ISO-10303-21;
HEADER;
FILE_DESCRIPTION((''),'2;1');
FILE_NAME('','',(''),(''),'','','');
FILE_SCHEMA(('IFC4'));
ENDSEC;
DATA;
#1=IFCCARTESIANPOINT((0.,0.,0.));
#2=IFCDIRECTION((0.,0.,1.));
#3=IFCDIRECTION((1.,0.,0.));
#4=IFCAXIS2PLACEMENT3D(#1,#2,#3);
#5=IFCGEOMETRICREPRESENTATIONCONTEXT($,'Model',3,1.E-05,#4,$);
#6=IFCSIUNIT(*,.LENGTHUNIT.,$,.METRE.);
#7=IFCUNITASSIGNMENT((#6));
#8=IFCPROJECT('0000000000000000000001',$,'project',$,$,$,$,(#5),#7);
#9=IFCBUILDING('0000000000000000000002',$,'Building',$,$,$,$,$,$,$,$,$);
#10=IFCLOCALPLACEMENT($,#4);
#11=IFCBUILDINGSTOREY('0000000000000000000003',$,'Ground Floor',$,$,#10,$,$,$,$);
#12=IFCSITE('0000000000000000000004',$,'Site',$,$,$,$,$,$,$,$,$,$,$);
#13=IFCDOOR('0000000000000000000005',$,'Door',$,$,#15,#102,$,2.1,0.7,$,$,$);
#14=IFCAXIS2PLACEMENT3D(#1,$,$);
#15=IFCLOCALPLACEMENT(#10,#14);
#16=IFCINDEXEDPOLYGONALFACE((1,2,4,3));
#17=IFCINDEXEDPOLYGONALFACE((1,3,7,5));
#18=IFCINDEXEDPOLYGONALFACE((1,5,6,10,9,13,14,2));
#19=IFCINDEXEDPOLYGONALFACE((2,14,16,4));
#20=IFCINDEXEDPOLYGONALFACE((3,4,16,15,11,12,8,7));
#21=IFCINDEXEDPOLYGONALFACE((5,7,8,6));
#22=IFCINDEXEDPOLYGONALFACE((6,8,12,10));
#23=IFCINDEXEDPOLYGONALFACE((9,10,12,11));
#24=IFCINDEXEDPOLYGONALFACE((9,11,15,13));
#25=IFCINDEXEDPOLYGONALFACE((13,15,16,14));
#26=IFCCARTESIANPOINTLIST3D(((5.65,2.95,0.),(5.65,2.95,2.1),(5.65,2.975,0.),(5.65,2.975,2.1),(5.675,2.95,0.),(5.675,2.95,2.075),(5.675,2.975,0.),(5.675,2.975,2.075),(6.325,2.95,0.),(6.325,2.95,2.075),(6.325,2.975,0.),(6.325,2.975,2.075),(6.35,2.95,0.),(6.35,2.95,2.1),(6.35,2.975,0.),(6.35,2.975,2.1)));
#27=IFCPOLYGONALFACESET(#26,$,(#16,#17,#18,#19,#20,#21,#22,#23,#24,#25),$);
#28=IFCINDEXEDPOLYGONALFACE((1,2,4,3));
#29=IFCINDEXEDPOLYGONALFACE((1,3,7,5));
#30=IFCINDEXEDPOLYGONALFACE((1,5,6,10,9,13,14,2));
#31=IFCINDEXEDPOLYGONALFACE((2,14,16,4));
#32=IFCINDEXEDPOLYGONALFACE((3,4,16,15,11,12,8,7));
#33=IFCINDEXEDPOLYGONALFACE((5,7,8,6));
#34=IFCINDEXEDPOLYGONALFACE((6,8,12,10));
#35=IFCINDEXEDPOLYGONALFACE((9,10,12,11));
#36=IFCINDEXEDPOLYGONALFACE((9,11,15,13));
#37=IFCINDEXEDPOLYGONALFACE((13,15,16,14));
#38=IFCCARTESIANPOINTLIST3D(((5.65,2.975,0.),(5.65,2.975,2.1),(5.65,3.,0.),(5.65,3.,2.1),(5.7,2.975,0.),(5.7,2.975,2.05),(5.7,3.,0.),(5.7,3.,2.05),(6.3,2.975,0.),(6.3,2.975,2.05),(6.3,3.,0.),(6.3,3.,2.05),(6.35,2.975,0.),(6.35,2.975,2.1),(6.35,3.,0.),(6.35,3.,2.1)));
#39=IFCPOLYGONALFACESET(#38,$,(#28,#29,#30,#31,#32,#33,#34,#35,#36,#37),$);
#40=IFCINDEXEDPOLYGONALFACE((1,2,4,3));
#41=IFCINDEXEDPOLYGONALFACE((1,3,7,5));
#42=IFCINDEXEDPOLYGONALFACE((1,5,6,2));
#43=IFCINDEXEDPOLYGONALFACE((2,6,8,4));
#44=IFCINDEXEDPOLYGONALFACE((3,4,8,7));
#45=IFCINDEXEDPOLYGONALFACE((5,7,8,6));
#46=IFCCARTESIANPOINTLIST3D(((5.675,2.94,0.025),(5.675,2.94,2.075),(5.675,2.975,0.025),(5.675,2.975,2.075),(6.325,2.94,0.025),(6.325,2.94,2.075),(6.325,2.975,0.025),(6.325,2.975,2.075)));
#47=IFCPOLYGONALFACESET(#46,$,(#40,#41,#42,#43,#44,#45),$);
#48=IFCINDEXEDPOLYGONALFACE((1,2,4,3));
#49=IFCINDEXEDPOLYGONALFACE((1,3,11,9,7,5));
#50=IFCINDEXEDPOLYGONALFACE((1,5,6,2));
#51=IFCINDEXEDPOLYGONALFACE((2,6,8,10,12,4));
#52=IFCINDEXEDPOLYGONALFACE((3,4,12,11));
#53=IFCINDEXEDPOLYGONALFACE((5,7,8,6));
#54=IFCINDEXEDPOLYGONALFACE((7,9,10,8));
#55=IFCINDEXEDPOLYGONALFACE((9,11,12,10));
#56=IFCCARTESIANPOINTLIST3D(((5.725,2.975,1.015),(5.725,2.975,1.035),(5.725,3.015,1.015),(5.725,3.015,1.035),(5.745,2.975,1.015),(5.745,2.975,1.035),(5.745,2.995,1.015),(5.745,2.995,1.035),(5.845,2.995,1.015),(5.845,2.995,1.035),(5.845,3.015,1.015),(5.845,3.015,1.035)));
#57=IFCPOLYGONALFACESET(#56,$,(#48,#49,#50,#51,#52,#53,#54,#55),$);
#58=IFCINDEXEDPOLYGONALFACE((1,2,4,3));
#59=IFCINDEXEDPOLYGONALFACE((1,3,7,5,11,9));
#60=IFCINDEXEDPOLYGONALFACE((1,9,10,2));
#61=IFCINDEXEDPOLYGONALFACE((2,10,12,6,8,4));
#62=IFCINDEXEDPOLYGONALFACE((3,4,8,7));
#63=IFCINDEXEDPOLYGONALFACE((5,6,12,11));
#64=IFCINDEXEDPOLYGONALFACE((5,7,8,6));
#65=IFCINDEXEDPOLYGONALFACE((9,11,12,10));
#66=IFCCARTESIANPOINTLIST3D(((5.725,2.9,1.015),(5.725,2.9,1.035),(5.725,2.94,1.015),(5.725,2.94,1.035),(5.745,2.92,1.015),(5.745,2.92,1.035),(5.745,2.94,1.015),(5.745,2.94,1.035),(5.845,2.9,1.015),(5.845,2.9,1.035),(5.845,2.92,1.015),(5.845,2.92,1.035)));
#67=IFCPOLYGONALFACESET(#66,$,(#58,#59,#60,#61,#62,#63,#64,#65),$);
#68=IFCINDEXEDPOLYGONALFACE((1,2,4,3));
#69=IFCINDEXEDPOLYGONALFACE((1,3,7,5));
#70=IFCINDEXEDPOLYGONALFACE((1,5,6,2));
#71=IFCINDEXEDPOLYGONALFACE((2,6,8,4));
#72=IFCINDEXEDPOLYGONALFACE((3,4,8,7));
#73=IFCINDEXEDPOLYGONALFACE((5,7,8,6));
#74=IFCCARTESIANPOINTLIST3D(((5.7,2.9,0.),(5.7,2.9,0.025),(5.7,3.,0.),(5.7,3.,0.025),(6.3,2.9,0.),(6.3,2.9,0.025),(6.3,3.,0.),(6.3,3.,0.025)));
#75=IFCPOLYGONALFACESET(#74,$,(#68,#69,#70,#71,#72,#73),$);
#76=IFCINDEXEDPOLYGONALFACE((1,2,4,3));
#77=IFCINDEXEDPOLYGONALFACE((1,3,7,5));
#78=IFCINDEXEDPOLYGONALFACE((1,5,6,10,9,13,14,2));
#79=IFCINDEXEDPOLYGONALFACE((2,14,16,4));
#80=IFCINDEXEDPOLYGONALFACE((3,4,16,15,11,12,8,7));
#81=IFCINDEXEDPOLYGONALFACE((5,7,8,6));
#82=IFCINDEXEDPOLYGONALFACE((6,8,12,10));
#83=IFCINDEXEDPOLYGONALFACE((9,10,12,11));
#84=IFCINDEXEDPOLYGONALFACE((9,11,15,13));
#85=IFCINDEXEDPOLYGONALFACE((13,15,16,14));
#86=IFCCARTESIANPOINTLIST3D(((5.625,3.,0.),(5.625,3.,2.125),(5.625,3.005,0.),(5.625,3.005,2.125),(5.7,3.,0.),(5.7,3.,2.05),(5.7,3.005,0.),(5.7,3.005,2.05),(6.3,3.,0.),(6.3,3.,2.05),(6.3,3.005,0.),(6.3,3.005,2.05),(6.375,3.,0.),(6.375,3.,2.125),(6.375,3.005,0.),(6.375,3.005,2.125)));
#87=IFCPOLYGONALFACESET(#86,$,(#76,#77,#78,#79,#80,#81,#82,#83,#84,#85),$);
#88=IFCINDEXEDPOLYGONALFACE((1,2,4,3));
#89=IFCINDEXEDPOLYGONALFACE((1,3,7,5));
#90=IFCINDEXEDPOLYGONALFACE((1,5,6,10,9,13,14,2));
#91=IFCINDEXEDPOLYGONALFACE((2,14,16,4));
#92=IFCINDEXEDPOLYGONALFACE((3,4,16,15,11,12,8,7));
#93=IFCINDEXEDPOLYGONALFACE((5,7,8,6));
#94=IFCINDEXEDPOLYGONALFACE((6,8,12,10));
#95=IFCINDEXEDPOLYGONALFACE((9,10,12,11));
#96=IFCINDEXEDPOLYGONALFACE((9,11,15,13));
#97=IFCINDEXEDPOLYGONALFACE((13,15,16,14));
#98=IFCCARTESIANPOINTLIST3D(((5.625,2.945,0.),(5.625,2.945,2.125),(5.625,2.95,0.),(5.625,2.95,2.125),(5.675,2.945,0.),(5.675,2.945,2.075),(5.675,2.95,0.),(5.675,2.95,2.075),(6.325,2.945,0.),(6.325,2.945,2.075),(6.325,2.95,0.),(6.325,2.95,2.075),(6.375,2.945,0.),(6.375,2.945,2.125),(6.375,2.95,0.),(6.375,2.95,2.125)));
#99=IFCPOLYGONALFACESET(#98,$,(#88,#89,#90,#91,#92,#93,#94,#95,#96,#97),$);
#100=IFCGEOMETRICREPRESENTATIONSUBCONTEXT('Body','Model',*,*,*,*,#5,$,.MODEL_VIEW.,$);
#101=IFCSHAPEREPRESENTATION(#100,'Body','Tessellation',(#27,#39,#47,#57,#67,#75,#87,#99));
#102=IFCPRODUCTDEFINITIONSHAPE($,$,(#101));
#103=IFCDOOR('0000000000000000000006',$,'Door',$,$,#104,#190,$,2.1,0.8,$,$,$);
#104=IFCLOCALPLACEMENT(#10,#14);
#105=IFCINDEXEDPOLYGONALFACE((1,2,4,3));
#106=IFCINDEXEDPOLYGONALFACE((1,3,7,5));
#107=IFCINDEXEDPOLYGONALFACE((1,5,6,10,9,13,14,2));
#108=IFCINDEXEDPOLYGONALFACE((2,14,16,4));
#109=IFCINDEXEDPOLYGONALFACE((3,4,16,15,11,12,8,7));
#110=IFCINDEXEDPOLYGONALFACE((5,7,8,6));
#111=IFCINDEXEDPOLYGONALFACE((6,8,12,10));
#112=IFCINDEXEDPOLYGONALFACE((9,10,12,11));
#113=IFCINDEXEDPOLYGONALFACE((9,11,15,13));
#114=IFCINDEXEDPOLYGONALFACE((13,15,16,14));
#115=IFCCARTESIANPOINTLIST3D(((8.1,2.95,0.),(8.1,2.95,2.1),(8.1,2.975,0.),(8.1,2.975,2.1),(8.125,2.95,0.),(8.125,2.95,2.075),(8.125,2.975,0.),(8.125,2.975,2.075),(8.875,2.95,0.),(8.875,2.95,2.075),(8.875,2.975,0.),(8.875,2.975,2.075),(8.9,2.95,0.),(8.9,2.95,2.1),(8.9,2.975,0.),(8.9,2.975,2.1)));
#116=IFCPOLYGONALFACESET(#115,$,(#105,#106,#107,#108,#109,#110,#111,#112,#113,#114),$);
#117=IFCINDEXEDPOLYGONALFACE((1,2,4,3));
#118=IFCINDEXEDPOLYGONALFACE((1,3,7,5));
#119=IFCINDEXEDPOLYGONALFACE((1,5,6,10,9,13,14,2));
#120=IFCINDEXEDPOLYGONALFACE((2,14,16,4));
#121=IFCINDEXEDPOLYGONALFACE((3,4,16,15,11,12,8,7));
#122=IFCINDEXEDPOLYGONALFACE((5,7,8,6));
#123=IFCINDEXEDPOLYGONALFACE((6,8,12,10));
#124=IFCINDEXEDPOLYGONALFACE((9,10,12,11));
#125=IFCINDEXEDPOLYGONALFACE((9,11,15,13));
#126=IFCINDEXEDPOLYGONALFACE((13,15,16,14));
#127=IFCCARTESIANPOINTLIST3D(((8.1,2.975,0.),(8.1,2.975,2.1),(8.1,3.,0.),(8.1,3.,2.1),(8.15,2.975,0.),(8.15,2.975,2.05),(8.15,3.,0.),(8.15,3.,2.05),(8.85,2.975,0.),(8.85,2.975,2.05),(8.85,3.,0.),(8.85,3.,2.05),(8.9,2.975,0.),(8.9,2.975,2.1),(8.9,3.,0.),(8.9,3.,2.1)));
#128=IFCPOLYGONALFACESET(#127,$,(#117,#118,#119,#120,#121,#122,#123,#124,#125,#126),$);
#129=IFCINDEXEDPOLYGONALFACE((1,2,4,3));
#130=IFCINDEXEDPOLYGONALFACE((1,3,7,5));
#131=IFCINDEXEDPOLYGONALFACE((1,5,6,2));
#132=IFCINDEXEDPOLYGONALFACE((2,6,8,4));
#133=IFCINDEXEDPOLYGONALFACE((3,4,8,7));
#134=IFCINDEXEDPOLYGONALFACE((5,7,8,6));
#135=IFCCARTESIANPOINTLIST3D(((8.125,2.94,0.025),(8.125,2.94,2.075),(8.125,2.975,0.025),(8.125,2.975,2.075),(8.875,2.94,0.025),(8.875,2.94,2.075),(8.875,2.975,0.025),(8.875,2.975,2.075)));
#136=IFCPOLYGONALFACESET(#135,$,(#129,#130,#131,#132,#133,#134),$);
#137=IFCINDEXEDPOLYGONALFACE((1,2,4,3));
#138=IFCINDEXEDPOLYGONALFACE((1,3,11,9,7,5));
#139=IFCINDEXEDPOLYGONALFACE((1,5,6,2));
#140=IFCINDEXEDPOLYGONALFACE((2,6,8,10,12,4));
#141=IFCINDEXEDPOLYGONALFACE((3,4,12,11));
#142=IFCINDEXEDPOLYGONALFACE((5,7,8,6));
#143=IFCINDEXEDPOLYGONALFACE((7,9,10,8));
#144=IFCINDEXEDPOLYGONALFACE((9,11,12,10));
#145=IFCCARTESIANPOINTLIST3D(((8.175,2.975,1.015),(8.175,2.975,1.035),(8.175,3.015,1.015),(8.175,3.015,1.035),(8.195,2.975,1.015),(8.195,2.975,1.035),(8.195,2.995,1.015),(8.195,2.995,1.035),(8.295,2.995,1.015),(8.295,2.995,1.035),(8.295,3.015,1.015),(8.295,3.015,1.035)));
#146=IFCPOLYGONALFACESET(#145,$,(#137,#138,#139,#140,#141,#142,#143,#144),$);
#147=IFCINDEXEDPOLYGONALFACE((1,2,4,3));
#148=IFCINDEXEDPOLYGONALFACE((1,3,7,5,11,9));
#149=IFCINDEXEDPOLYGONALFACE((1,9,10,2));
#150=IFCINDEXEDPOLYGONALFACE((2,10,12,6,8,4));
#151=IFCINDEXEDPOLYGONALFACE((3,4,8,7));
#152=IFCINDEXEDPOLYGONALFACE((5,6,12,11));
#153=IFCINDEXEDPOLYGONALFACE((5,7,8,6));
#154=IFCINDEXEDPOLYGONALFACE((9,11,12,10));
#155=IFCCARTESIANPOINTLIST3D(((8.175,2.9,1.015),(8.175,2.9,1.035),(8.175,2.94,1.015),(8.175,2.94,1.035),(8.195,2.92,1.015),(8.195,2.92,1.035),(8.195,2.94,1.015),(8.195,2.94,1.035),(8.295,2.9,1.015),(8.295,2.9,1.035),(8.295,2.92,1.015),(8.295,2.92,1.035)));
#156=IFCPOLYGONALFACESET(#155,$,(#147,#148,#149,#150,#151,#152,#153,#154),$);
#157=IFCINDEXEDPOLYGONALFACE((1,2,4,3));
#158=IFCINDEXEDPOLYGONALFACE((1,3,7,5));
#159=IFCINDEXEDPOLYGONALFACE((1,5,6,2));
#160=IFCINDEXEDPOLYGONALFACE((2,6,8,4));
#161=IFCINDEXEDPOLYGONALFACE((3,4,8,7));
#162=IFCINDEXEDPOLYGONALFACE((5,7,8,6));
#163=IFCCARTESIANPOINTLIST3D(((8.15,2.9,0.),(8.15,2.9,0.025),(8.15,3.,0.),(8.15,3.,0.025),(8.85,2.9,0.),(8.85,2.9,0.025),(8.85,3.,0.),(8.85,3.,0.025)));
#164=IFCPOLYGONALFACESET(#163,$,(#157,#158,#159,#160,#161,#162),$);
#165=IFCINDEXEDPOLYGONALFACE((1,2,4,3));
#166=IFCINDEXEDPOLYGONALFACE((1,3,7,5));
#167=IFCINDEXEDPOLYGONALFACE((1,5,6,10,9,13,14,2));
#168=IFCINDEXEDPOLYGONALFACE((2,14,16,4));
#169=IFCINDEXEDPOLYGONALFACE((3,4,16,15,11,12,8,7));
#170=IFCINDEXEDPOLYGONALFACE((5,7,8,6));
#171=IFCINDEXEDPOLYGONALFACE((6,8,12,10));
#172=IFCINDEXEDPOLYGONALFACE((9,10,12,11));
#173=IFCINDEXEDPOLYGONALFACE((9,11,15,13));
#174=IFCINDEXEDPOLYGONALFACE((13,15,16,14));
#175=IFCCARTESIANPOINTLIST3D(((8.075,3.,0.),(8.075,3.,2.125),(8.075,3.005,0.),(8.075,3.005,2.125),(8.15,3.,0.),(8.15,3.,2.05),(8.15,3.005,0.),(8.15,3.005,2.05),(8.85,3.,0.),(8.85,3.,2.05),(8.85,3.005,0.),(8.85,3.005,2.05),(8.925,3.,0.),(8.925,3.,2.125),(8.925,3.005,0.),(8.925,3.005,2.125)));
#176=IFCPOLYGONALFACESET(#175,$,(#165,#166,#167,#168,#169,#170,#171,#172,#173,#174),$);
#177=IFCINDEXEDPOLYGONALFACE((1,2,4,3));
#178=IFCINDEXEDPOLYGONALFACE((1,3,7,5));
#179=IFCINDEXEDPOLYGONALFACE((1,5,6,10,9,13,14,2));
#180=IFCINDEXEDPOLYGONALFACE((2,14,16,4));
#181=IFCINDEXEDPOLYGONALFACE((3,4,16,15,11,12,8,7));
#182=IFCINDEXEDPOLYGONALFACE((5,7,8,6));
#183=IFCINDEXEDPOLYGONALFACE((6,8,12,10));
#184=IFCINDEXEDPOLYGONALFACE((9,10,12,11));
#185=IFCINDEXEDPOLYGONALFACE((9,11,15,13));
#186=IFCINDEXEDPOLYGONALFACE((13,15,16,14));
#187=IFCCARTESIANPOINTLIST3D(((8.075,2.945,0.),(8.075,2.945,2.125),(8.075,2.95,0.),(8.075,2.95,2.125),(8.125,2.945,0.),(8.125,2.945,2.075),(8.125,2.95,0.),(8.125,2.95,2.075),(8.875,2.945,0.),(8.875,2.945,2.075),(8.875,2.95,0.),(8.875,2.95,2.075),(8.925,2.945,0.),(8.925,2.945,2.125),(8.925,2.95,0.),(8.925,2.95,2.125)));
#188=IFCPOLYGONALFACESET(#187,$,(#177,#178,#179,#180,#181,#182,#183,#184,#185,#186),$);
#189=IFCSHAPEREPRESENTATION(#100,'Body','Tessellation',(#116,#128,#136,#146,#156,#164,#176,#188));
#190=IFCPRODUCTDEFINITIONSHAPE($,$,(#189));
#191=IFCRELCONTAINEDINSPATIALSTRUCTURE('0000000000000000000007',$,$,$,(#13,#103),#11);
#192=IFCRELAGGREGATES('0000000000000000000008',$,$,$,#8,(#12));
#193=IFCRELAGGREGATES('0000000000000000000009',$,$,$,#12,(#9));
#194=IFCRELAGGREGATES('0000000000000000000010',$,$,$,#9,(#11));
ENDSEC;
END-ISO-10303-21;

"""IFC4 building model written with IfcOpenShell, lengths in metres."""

from ifc_helpers import new_model, si_unit, frame, origin_with_axes, place, context, subcontext, project, spatial, line, indexed_curve, outline, extrude, element, save


model = new_model("IFC4")

# Units and contexts
model_context = context("Model", 3, precision=1e-05, world=origin_with_axes())
body_context = subcontext(model_context, "Body", "Model", "MODEL_VIEW")
ifc_project = project(units=[si_unit("LENGTHUNIT", "METRE")], contexts=[model_context])

# Site, building, storey
site = spatial("IfcSite", under=ifc_project, Name="Site")
building = spatial("IfcBuilding", under=site, Name="Building")
storey_placement = place(None, origin_with_axes())
storey = spatial("IfcBuildingStorey", under=building, at=storey_placement, Name="Ground Floor")

# Doors
door_1_placement = place(storey_placement, frame((6.35, 3.0, 0.0), z_axis=(0.0, 0.0, 1.0), x_axis=(-1.0, 0.0, 0.0)))
element("IfcDoor", 1, at=door_1_placement, inside=storey, Name="Door", OverallHeight=2.1, OverallWidth=0.7, context=body_context, shape_type="SweptSolid", body=[
    extrude(outline(indexed_curve([(0.0, 0.0), (0.0, 2.1), (0.7, 2.1), (0.7, 0.0), (0.675, 0.0), (0.675, 2.075), (0.025, 2.075), (0.025, 0.0)], segments=[line(1, 2, 3, 4, 5, 6, 7, 8, 1)])), frame((0.0, 0.025, 0.0), z_axis=(0.0, -1.0, 0.0), x_axis=(1.0, 0.0, 0.0)), (0.0, 0.0, -1.0), 0.025),
    extrude(outline(indexed_curve([(0.0, 0.0), (0.0, 2.1), (0.7, 2.1), (0.7, 0.0), (0.65, 0.0), (0.65, 2.05), (0.05, 2.05), (0.05, 0.0)], segments=[line(1, 2, 3, 4, 5, 6, 7, 8, 1)])), frame((0.0, 0.0, 0.0), z_axis=(0.0, -1.0, 0.0), x_axis=(1.0, 0.0, 0.0)), (0.0, 0.0, -1.0), 0.025),
    extrude(outline(indexed_curve([(0.0, 0.0), (0.65, 0.0), (0.65, 0.035), (0.0, 0.035)], segments=[line(1, 2, 3, 4, 1)])), frame((0.025, 0.025, 0.025), z_axis=(0.0, 0.0, 1.0), x_axis=(1.0, 0.0, 0.0)), (0.0, 0.0, 1.0), 2.05),
    extrude(outline(indexed_curve([(0.0, 0.0), (0.0, -0.04), (-0.12, -0.04), (-0.12, -0.02), (-0.02, -0.02), (-0.02, 0.0)], segments=[line(1, 2, 3, 4, 5, 6, 1)])), frame((0.625, 0.025, 1.015), z_axis=(0.0, 0.0, 1.0), x_axis=(1.0, 0.0, 0.0)), (0.0, 0.0, 1.0), 0.02),
    extrude(outline(indexed_curve([(0.0, 0.0), (0.0, 0.04), (-0.12, 0.04), (-0.12, 0.02), (-0.02, 0.02), (-0.02, 0.0)], segments=[line(1, 2, 3, 4, 5, 6, 1)])), frame((0.625, 0.06, 1.015), z_axis=(0.0, 0.0, 1.0), x_axis=(1.0, 0.0, 0.0)), (0.0, 0.0, 1.0), 0.02),
    extrude(outline(indexed_curve([(0.0, 0.0), (0.6, 0.0), (0.6, 0.1), (0.0, 0.1)], segments=[line(1, 2, 3, 4, 1)])), frame((0.05, 0.0, 0.0), z_axis=(0.0, 0.0, 1.0), x_axis=(1.0, 0.0, 0.0)), (0.0, 0.0, 1.0), 0.025),
    extrude(outline(indexed_curve([(0.0, 0.0), (0.0, 2.125), (0.75, 2.125), (0.75, 0.0), (0.675, 0.0), (0.675, 2.05), (0.075, 2.05), (0.075, 0.0)], segments=[line(1, 2, 3, 4, 5, 6, 7, 8, 1)])), frame((-0.025, -0.005, 0.0), z_axis=(0.0, -1.0, 0.0), x_axis=(1.0, 0.0, 0.0)), (0.0, 0.0, -1.0), 0.005),
    extrude(outline(indexed_curve([(0.0, 0.0), (0.0, 2.125), (0.75, 2.125), (0.75, 0.0), (0.7, 0.0), (0.7, 2.075), (0.05, 2.075), (0.05, 0.0)], segments=[line(1, 2, 3, 4, 5, 6, 7, 8, 1)])), frame((-0.025, 0.05, 0.0), z_axis=(0.0, -1.0, 0.0), x_axis=(1.0, 0.0, 0.0)), (0.0, 0.0, -1.0), 0.005),
])
door_2_placement = place(storey_placement, frame((8.9, 3.0, 0.0), z_axis=(0.0, 0.0, 1.0), x_axis=(-1.0, 0.0, 0.0)))
element("IfcDoor", 2, at=door_2_placement, inside=storey, Name="Door", OverallHeight=2.1, OverallWidth=0.8, context=body_context, shape_type="SweptSolid", body=[
    extrude(outline(indexed_curve([(0.0, 0.0), (0.0, 2.1), (0.8, 2.1), (0.8, 0.0), (0.775, 0.0), (0.775, 2.075), (0.025, 2.075), (0.025, 0.0)], segments=[line(1, 2, 3, 4, 5, 6, 7, 8, 1)])), frame((0.0, 0.025, 0.0), z_axis=(0.0, -1.0, 0.0), x_axis=(1.0, 0.0, 0.0)), (0.0, 0.0, -1.0), 0.025),
    extrude(outline(indexed_curve([(0.0, 0.0), (0.0, 2.1), (0.8, 2.1), (0.8, 0.0), (0.75, 0.0), (0.75, 2.05), (0.05, 2.05), (0.05, 0.0)], segments=[line(1, 2, 3, 4, 5, 6, 7, 8, 1)])), frame((0.0, 0.0, 0.0), z_axis=(0.0, -1.0, 0.0), x_axis=(1.0, 0.0, 0.0)), (0.0, 0.0, -1.0), 0.025),
    extrude(outline(indexed_curve([(0.0, 0.0), (0.75, 0.0), (0.75, 0.035), (0.0, 0.035)], segments=[line(1, 2, 3, 4, 1)])), frame((0.025, 0.025, 0.025), z_axis=(0.0, 0.0, 1.0), x_axis=(1.0, 0.0, 0.0)), (0.0, 0.0, 1.0), 2.05),
    extrude(outline(indexed_curve([(0.0, 0.0), (0.0, -0.04), (-0.12, -0.04), (-0.12, -0.02), (-0.02, -0.02), (-0.02, 0.0)], segments=[line(1, 2, 3, 4, 5, 6, 1)])), frame((0.725, 0.025, 1.015), z_axis=(0.0, 0.0, 1.0), x_axis=(1.0, 0.0, 0.0)), (0.0, 0.0, 1.0), 0.02),
    extrude(outline(indexed_curve([(0.0, 0.0), (0.0, 0.04), (-0.12, 0.04), (-0.12, 0.02), (-0.02, 0.02), (-0.02, 0.0)], segments=[line(1, 2, 3, 4, 5, 6, 1)])), frame((0.725, 0.06, 1.015), z_axis=(0.0, 0.0, 1.0), x_axis=(1.0, 0.0, 0.0)), (0.0, 0.0, 1.0), 0.02),
    extrude(outline(indexed_curve([(0.0, 0.0), (0.7, 0.0), (0.7, 0.1), (0.0, 0.1)], segments=[line(1, 2, 3, 4, 1)])), frame((0.05, 0.0, 0.0), z_axis=(0.0, 0.0, 1.0), x_axis=(1.0, 0.0, 0.0)), (0.0, 0.0, 1.0), 0.025),
    extrude(outline(indexed_curve([(0.0, 0.0), (0.0, 2.125), (0.85, 2.125), (0.85, 0.0), (0.775, 0.0), (0.775, 2.05), (0.075, 2.05), (0.075, 0.0)], segments=[line(1, 2, 3, 4, 5, 6, 7, 8, 1)])), frame((-0.025, -0.005, 0.0), z_axis=(0.0, -1.0, 0.0), x_axis=(1.0, 0.0, 0.0)), (0.0, 0.0, -1.0), 0.005),
    extrude(outline(indexed_curve([(0.0, 0.0), (0.0, 2.125), (0.85, 2.125), (0.85, 0.0), (0.8, 0.0), (0.8, 2.075), (0.05, 2.075), (0.05, 0.0)], segments=[line(1, 2, 3, 4, 5, 6, 7, 8, 1)])), frame((-0.025, 0.05, 0.0), z_axis=(0.0, -1.0, 0.0), x_axis=(1.0, 0.0, 0.0)), (0.0, 0.0, -1.0), 0.005),
])

save(model, "model.ifc")
